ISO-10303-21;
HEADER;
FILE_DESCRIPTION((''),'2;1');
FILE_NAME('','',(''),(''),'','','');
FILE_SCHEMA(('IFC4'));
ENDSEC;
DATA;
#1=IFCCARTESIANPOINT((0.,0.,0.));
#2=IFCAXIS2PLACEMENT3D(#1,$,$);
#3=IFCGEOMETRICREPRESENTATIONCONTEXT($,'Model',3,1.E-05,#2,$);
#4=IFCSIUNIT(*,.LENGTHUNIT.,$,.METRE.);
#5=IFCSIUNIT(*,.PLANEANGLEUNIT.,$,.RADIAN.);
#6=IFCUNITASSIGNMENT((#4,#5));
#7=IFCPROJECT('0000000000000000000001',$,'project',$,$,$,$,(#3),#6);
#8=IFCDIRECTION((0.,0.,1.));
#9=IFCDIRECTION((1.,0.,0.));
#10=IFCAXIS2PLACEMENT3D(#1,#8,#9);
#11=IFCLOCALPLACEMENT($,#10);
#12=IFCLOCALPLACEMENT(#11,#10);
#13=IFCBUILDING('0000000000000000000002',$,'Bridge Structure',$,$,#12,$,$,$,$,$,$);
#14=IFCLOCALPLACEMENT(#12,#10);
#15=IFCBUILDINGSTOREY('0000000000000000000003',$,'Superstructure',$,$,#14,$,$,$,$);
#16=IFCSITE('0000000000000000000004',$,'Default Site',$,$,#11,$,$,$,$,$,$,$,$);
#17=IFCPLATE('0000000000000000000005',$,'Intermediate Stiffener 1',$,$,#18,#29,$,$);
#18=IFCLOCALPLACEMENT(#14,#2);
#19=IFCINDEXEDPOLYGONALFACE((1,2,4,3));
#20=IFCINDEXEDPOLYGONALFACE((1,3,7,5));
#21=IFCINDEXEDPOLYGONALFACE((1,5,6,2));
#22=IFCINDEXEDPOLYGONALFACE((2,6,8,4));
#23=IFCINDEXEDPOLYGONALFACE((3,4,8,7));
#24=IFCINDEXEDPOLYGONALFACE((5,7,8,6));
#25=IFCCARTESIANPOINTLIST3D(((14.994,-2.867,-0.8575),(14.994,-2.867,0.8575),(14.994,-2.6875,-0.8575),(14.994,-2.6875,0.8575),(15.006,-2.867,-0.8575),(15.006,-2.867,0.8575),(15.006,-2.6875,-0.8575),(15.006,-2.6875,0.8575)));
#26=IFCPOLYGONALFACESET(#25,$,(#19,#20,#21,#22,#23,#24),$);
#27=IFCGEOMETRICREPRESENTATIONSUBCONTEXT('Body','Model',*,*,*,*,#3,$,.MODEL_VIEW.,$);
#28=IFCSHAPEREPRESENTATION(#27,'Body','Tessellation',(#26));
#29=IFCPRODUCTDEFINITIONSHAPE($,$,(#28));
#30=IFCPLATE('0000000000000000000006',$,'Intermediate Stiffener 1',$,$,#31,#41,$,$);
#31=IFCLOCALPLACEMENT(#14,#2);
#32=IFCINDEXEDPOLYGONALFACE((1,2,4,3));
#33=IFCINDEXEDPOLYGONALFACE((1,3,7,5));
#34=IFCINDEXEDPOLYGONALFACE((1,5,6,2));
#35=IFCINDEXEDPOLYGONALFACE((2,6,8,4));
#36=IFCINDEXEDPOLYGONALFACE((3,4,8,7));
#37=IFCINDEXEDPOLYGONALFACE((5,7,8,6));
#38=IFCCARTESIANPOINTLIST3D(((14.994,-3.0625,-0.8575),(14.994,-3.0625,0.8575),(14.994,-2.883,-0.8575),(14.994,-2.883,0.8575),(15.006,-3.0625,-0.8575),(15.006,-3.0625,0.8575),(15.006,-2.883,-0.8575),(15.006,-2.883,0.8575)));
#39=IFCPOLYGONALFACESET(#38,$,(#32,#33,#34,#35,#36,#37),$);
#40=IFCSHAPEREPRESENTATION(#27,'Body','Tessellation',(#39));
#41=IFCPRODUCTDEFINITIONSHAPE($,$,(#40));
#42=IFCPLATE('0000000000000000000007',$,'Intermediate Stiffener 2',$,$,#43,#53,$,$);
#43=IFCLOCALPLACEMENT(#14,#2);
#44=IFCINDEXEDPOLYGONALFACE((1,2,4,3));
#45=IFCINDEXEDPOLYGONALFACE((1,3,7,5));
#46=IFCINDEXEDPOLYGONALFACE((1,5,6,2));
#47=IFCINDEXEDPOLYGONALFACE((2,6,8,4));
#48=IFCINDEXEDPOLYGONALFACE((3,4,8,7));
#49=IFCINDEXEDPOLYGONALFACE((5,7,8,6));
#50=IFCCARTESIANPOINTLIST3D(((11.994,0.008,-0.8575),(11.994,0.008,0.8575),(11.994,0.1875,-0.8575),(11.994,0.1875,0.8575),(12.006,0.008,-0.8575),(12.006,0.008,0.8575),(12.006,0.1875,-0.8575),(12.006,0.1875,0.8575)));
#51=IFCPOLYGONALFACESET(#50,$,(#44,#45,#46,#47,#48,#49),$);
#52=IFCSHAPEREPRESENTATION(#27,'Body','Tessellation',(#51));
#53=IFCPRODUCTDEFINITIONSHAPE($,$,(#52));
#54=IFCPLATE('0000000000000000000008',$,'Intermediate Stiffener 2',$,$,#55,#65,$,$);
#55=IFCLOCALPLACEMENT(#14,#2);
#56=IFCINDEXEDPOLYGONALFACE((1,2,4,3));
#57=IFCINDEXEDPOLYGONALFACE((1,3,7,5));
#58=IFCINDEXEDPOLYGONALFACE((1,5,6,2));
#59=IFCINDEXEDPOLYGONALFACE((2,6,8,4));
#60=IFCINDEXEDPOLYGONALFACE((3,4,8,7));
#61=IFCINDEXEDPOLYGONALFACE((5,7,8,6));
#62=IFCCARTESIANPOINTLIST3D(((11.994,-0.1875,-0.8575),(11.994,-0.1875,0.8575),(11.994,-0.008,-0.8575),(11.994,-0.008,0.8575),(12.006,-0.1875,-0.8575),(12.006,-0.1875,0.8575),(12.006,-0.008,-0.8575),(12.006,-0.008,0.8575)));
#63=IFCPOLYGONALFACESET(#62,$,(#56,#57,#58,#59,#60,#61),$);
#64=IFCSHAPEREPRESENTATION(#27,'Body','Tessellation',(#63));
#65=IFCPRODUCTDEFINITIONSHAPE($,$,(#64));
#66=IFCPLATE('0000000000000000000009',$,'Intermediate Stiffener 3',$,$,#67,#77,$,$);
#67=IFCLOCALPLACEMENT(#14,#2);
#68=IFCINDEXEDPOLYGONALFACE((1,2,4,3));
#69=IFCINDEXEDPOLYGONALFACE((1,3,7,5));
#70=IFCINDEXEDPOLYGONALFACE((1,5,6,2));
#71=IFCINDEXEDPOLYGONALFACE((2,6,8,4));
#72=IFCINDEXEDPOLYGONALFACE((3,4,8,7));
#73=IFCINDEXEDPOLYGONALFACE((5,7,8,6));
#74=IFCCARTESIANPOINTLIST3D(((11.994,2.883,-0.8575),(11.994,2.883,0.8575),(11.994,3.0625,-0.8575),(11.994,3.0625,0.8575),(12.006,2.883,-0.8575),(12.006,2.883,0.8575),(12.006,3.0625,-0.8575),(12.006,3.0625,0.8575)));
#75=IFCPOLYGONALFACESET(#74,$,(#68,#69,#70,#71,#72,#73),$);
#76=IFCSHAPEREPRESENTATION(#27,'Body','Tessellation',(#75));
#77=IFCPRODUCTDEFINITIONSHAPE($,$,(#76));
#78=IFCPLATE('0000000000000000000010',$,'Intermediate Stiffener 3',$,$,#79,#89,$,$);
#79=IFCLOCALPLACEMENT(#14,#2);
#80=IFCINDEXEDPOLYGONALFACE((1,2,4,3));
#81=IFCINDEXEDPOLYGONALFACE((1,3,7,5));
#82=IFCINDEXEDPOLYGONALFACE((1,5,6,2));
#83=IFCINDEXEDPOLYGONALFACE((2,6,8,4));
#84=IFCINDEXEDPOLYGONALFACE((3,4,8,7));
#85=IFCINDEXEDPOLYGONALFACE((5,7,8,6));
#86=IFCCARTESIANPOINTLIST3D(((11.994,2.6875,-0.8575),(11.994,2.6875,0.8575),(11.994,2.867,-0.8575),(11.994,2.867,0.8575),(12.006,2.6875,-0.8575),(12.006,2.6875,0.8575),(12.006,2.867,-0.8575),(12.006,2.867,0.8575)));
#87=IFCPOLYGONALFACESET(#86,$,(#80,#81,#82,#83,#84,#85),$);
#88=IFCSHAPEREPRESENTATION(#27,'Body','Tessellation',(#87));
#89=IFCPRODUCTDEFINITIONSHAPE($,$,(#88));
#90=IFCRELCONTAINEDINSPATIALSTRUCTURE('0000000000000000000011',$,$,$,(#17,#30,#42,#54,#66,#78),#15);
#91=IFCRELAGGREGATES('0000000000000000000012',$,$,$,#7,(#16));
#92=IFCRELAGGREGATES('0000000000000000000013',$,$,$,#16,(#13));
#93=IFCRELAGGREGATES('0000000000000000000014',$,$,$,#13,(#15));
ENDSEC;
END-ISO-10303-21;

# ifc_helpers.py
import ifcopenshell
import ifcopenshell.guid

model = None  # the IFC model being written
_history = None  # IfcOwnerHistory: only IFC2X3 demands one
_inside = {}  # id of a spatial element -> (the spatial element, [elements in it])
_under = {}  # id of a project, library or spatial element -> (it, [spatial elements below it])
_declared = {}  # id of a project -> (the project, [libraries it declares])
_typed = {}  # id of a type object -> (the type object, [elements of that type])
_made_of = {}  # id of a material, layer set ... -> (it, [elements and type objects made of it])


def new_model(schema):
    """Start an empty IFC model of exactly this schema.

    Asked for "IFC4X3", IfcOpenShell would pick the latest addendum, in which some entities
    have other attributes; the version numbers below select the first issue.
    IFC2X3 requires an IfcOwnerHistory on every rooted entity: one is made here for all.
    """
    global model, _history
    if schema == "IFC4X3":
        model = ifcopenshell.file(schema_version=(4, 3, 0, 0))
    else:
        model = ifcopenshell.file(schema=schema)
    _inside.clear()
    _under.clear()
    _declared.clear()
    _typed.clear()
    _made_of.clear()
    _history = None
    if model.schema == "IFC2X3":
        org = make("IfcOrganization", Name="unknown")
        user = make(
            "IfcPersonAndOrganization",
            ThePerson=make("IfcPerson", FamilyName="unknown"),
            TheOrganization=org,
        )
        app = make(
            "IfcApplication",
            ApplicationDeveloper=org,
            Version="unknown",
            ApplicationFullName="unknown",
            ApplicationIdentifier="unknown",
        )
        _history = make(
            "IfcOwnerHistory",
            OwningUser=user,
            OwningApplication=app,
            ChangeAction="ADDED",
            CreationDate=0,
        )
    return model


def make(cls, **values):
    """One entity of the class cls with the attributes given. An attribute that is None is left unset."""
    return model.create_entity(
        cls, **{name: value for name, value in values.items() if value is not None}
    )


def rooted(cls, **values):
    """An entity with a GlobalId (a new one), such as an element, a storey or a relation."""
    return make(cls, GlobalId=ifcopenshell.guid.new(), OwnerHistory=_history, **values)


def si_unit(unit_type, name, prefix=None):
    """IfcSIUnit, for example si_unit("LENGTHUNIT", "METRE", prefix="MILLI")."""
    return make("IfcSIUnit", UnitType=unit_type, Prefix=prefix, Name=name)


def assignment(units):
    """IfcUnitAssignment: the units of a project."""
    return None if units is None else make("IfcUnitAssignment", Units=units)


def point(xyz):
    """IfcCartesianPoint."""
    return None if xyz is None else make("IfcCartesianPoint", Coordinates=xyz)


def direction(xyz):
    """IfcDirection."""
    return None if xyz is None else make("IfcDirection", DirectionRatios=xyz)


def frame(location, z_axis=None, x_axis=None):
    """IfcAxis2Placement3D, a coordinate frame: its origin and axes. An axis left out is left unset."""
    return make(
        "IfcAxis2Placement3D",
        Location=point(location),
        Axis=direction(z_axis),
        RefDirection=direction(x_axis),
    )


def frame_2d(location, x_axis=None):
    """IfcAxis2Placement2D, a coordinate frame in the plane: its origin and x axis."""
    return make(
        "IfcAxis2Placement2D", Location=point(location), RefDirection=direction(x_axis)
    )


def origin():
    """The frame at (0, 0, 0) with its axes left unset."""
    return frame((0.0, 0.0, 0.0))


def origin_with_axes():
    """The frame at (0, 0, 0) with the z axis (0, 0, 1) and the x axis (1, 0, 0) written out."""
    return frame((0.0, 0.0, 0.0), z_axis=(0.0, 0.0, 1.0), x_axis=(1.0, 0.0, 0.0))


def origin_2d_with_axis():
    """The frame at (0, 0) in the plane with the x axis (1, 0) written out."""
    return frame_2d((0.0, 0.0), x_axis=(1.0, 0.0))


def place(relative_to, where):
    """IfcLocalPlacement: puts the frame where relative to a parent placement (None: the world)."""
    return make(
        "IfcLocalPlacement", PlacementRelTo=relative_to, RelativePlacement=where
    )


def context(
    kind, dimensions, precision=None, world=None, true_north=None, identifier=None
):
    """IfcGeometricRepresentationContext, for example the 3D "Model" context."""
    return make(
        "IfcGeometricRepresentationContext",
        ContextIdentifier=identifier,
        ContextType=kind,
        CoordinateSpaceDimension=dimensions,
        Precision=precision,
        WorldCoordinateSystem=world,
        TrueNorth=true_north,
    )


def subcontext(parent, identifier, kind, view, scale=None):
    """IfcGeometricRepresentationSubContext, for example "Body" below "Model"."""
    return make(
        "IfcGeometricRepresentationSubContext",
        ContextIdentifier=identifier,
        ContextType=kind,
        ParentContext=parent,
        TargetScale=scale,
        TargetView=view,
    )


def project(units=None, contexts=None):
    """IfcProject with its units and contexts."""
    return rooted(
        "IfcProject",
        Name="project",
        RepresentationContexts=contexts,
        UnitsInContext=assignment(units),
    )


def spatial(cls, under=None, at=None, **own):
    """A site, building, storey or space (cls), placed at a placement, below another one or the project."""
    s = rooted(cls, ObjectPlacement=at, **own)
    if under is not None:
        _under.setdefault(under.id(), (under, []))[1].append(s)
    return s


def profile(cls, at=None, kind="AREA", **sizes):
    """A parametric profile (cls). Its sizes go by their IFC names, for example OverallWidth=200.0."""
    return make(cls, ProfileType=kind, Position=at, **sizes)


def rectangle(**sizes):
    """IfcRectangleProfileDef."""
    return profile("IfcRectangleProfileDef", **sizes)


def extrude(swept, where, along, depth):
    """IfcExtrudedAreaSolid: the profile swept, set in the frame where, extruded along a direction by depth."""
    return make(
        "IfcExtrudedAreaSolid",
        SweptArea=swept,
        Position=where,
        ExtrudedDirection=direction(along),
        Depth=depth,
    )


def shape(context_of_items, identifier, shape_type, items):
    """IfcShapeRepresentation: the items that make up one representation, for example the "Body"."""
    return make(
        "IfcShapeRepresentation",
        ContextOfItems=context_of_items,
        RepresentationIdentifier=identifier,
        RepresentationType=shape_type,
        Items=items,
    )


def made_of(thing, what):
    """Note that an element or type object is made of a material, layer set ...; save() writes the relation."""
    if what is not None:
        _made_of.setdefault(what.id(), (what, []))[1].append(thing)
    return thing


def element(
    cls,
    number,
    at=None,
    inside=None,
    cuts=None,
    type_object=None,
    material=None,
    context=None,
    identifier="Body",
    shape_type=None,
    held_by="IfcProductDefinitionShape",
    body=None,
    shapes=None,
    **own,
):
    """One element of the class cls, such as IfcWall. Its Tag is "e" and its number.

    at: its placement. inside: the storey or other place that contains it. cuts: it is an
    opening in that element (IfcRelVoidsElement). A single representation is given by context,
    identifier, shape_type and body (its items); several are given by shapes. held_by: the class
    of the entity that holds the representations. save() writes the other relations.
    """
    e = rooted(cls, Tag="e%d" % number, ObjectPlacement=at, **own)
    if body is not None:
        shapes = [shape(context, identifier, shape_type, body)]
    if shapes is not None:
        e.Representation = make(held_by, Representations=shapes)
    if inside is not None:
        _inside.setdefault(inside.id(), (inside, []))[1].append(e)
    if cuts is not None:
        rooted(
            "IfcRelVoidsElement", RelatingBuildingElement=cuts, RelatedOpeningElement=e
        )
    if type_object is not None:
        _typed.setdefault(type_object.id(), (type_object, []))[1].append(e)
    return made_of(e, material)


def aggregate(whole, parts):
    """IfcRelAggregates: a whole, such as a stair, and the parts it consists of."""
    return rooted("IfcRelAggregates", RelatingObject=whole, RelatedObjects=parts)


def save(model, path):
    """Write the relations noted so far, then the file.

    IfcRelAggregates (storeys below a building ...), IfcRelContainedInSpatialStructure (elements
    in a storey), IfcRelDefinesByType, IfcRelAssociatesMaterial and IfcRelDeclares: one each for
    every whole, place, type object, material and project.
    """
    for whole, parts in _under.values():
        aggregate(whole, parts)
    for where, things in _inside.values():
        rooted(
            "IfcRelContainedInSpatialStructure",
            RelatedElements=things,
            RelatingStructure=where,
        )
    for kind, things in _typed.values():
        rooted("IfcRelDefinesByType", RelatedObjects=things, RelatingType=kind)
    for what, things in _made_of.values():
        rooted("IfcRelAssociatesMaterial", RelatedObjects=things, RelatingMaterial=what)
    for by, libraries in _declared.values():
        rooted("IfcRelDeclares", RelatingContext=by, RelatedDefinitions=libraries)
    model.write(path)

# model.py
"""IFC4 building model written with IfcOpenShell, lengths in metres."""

from ifc_helpers import new_model, si_unit, frame, origin, origin_with_axes, origin_2d_with_axis, place, context, subcontext, project, spatial, rectangle, extrude, element, save


model = new_model("IFC4")

# Units and contexts
model_context = context("Model", 3, precision=1e-05, world=origin())
body_context = subcontext(model_context, "Body", "Model", "MODEL_VIEW")
ifc_project = project(units=[si_unit("LENGTHUNIT", "METRE"), si_unit("PLANEANGLEUNIT", "RADIAN")], contexts=[model_context])

# Site, building, storey
site_placement = place(None, origin_with_axes())
site = spatial("IfcSite", under=ifc_project, at=site_placement, Name="Default Site")
building_placement = place(site_placement, origin_with_axes())
building = spatial("IfcBuilding", under=site, at=building_placement, Name="Bridge Structure")
storey_placement = place(building_placement, origin_with_axes())
storey = spatial("IfcBuildingStorey", under=building, at=storey_placement, Name="Superstructure")

# Plates
for number, where, z_axis, x_axis, name in (
    (1, (15.0, -2.7772, -0.8575), (0.0, 0.0, 1.0), (1.0, 0.0, 0.0), "Intermediate Stiffener 1"),
    (2, (15.0, -2.9728, -0.8575), (0.0, 0.0, 1.0), (1.0, 0.0, 0.0), "Intermediate Stiffener 1"),
    (3, (12.0, 0.0978, -0.8575), (0.0, 0.0, 1.0), (1.0, 0.0, 0.0), "Intermediate Stiffener 2"),
    (4, (12.0, -0.0978, -0.8575), (0.0, 0.0, 1.0), (1.0, 0.0, 0.0), "Intermediate Stiffener 2"),
    (5, (12.0, 2.9728, -0.8575), (0.0, 0.0, 1.0), (1.0, 0.0, 0.0), "Intermediate Stiffener 3"),
    (6, (12.0, 2.7772, -0.8575), (0.0, 0.0, 1.0), (1.0, 0.0, 0.0), "Intermediate Stiffener 3"),
):
    element("IfcPlate", number, at=place(storey_placement, frame(where, z_axis=z_axis, x_axis=x_axis)), inside=storey, Name=name, context=body_context, shape_type="SweptSolid", body=[
        extrude(rectangle(XDim=0.012, YDim=0.1795, at=origin_2d_with_axis()), origin_with_axes(), (0.0, 0.0, 1.0), 1.715),
    ])

save(model, "model.ifc")
